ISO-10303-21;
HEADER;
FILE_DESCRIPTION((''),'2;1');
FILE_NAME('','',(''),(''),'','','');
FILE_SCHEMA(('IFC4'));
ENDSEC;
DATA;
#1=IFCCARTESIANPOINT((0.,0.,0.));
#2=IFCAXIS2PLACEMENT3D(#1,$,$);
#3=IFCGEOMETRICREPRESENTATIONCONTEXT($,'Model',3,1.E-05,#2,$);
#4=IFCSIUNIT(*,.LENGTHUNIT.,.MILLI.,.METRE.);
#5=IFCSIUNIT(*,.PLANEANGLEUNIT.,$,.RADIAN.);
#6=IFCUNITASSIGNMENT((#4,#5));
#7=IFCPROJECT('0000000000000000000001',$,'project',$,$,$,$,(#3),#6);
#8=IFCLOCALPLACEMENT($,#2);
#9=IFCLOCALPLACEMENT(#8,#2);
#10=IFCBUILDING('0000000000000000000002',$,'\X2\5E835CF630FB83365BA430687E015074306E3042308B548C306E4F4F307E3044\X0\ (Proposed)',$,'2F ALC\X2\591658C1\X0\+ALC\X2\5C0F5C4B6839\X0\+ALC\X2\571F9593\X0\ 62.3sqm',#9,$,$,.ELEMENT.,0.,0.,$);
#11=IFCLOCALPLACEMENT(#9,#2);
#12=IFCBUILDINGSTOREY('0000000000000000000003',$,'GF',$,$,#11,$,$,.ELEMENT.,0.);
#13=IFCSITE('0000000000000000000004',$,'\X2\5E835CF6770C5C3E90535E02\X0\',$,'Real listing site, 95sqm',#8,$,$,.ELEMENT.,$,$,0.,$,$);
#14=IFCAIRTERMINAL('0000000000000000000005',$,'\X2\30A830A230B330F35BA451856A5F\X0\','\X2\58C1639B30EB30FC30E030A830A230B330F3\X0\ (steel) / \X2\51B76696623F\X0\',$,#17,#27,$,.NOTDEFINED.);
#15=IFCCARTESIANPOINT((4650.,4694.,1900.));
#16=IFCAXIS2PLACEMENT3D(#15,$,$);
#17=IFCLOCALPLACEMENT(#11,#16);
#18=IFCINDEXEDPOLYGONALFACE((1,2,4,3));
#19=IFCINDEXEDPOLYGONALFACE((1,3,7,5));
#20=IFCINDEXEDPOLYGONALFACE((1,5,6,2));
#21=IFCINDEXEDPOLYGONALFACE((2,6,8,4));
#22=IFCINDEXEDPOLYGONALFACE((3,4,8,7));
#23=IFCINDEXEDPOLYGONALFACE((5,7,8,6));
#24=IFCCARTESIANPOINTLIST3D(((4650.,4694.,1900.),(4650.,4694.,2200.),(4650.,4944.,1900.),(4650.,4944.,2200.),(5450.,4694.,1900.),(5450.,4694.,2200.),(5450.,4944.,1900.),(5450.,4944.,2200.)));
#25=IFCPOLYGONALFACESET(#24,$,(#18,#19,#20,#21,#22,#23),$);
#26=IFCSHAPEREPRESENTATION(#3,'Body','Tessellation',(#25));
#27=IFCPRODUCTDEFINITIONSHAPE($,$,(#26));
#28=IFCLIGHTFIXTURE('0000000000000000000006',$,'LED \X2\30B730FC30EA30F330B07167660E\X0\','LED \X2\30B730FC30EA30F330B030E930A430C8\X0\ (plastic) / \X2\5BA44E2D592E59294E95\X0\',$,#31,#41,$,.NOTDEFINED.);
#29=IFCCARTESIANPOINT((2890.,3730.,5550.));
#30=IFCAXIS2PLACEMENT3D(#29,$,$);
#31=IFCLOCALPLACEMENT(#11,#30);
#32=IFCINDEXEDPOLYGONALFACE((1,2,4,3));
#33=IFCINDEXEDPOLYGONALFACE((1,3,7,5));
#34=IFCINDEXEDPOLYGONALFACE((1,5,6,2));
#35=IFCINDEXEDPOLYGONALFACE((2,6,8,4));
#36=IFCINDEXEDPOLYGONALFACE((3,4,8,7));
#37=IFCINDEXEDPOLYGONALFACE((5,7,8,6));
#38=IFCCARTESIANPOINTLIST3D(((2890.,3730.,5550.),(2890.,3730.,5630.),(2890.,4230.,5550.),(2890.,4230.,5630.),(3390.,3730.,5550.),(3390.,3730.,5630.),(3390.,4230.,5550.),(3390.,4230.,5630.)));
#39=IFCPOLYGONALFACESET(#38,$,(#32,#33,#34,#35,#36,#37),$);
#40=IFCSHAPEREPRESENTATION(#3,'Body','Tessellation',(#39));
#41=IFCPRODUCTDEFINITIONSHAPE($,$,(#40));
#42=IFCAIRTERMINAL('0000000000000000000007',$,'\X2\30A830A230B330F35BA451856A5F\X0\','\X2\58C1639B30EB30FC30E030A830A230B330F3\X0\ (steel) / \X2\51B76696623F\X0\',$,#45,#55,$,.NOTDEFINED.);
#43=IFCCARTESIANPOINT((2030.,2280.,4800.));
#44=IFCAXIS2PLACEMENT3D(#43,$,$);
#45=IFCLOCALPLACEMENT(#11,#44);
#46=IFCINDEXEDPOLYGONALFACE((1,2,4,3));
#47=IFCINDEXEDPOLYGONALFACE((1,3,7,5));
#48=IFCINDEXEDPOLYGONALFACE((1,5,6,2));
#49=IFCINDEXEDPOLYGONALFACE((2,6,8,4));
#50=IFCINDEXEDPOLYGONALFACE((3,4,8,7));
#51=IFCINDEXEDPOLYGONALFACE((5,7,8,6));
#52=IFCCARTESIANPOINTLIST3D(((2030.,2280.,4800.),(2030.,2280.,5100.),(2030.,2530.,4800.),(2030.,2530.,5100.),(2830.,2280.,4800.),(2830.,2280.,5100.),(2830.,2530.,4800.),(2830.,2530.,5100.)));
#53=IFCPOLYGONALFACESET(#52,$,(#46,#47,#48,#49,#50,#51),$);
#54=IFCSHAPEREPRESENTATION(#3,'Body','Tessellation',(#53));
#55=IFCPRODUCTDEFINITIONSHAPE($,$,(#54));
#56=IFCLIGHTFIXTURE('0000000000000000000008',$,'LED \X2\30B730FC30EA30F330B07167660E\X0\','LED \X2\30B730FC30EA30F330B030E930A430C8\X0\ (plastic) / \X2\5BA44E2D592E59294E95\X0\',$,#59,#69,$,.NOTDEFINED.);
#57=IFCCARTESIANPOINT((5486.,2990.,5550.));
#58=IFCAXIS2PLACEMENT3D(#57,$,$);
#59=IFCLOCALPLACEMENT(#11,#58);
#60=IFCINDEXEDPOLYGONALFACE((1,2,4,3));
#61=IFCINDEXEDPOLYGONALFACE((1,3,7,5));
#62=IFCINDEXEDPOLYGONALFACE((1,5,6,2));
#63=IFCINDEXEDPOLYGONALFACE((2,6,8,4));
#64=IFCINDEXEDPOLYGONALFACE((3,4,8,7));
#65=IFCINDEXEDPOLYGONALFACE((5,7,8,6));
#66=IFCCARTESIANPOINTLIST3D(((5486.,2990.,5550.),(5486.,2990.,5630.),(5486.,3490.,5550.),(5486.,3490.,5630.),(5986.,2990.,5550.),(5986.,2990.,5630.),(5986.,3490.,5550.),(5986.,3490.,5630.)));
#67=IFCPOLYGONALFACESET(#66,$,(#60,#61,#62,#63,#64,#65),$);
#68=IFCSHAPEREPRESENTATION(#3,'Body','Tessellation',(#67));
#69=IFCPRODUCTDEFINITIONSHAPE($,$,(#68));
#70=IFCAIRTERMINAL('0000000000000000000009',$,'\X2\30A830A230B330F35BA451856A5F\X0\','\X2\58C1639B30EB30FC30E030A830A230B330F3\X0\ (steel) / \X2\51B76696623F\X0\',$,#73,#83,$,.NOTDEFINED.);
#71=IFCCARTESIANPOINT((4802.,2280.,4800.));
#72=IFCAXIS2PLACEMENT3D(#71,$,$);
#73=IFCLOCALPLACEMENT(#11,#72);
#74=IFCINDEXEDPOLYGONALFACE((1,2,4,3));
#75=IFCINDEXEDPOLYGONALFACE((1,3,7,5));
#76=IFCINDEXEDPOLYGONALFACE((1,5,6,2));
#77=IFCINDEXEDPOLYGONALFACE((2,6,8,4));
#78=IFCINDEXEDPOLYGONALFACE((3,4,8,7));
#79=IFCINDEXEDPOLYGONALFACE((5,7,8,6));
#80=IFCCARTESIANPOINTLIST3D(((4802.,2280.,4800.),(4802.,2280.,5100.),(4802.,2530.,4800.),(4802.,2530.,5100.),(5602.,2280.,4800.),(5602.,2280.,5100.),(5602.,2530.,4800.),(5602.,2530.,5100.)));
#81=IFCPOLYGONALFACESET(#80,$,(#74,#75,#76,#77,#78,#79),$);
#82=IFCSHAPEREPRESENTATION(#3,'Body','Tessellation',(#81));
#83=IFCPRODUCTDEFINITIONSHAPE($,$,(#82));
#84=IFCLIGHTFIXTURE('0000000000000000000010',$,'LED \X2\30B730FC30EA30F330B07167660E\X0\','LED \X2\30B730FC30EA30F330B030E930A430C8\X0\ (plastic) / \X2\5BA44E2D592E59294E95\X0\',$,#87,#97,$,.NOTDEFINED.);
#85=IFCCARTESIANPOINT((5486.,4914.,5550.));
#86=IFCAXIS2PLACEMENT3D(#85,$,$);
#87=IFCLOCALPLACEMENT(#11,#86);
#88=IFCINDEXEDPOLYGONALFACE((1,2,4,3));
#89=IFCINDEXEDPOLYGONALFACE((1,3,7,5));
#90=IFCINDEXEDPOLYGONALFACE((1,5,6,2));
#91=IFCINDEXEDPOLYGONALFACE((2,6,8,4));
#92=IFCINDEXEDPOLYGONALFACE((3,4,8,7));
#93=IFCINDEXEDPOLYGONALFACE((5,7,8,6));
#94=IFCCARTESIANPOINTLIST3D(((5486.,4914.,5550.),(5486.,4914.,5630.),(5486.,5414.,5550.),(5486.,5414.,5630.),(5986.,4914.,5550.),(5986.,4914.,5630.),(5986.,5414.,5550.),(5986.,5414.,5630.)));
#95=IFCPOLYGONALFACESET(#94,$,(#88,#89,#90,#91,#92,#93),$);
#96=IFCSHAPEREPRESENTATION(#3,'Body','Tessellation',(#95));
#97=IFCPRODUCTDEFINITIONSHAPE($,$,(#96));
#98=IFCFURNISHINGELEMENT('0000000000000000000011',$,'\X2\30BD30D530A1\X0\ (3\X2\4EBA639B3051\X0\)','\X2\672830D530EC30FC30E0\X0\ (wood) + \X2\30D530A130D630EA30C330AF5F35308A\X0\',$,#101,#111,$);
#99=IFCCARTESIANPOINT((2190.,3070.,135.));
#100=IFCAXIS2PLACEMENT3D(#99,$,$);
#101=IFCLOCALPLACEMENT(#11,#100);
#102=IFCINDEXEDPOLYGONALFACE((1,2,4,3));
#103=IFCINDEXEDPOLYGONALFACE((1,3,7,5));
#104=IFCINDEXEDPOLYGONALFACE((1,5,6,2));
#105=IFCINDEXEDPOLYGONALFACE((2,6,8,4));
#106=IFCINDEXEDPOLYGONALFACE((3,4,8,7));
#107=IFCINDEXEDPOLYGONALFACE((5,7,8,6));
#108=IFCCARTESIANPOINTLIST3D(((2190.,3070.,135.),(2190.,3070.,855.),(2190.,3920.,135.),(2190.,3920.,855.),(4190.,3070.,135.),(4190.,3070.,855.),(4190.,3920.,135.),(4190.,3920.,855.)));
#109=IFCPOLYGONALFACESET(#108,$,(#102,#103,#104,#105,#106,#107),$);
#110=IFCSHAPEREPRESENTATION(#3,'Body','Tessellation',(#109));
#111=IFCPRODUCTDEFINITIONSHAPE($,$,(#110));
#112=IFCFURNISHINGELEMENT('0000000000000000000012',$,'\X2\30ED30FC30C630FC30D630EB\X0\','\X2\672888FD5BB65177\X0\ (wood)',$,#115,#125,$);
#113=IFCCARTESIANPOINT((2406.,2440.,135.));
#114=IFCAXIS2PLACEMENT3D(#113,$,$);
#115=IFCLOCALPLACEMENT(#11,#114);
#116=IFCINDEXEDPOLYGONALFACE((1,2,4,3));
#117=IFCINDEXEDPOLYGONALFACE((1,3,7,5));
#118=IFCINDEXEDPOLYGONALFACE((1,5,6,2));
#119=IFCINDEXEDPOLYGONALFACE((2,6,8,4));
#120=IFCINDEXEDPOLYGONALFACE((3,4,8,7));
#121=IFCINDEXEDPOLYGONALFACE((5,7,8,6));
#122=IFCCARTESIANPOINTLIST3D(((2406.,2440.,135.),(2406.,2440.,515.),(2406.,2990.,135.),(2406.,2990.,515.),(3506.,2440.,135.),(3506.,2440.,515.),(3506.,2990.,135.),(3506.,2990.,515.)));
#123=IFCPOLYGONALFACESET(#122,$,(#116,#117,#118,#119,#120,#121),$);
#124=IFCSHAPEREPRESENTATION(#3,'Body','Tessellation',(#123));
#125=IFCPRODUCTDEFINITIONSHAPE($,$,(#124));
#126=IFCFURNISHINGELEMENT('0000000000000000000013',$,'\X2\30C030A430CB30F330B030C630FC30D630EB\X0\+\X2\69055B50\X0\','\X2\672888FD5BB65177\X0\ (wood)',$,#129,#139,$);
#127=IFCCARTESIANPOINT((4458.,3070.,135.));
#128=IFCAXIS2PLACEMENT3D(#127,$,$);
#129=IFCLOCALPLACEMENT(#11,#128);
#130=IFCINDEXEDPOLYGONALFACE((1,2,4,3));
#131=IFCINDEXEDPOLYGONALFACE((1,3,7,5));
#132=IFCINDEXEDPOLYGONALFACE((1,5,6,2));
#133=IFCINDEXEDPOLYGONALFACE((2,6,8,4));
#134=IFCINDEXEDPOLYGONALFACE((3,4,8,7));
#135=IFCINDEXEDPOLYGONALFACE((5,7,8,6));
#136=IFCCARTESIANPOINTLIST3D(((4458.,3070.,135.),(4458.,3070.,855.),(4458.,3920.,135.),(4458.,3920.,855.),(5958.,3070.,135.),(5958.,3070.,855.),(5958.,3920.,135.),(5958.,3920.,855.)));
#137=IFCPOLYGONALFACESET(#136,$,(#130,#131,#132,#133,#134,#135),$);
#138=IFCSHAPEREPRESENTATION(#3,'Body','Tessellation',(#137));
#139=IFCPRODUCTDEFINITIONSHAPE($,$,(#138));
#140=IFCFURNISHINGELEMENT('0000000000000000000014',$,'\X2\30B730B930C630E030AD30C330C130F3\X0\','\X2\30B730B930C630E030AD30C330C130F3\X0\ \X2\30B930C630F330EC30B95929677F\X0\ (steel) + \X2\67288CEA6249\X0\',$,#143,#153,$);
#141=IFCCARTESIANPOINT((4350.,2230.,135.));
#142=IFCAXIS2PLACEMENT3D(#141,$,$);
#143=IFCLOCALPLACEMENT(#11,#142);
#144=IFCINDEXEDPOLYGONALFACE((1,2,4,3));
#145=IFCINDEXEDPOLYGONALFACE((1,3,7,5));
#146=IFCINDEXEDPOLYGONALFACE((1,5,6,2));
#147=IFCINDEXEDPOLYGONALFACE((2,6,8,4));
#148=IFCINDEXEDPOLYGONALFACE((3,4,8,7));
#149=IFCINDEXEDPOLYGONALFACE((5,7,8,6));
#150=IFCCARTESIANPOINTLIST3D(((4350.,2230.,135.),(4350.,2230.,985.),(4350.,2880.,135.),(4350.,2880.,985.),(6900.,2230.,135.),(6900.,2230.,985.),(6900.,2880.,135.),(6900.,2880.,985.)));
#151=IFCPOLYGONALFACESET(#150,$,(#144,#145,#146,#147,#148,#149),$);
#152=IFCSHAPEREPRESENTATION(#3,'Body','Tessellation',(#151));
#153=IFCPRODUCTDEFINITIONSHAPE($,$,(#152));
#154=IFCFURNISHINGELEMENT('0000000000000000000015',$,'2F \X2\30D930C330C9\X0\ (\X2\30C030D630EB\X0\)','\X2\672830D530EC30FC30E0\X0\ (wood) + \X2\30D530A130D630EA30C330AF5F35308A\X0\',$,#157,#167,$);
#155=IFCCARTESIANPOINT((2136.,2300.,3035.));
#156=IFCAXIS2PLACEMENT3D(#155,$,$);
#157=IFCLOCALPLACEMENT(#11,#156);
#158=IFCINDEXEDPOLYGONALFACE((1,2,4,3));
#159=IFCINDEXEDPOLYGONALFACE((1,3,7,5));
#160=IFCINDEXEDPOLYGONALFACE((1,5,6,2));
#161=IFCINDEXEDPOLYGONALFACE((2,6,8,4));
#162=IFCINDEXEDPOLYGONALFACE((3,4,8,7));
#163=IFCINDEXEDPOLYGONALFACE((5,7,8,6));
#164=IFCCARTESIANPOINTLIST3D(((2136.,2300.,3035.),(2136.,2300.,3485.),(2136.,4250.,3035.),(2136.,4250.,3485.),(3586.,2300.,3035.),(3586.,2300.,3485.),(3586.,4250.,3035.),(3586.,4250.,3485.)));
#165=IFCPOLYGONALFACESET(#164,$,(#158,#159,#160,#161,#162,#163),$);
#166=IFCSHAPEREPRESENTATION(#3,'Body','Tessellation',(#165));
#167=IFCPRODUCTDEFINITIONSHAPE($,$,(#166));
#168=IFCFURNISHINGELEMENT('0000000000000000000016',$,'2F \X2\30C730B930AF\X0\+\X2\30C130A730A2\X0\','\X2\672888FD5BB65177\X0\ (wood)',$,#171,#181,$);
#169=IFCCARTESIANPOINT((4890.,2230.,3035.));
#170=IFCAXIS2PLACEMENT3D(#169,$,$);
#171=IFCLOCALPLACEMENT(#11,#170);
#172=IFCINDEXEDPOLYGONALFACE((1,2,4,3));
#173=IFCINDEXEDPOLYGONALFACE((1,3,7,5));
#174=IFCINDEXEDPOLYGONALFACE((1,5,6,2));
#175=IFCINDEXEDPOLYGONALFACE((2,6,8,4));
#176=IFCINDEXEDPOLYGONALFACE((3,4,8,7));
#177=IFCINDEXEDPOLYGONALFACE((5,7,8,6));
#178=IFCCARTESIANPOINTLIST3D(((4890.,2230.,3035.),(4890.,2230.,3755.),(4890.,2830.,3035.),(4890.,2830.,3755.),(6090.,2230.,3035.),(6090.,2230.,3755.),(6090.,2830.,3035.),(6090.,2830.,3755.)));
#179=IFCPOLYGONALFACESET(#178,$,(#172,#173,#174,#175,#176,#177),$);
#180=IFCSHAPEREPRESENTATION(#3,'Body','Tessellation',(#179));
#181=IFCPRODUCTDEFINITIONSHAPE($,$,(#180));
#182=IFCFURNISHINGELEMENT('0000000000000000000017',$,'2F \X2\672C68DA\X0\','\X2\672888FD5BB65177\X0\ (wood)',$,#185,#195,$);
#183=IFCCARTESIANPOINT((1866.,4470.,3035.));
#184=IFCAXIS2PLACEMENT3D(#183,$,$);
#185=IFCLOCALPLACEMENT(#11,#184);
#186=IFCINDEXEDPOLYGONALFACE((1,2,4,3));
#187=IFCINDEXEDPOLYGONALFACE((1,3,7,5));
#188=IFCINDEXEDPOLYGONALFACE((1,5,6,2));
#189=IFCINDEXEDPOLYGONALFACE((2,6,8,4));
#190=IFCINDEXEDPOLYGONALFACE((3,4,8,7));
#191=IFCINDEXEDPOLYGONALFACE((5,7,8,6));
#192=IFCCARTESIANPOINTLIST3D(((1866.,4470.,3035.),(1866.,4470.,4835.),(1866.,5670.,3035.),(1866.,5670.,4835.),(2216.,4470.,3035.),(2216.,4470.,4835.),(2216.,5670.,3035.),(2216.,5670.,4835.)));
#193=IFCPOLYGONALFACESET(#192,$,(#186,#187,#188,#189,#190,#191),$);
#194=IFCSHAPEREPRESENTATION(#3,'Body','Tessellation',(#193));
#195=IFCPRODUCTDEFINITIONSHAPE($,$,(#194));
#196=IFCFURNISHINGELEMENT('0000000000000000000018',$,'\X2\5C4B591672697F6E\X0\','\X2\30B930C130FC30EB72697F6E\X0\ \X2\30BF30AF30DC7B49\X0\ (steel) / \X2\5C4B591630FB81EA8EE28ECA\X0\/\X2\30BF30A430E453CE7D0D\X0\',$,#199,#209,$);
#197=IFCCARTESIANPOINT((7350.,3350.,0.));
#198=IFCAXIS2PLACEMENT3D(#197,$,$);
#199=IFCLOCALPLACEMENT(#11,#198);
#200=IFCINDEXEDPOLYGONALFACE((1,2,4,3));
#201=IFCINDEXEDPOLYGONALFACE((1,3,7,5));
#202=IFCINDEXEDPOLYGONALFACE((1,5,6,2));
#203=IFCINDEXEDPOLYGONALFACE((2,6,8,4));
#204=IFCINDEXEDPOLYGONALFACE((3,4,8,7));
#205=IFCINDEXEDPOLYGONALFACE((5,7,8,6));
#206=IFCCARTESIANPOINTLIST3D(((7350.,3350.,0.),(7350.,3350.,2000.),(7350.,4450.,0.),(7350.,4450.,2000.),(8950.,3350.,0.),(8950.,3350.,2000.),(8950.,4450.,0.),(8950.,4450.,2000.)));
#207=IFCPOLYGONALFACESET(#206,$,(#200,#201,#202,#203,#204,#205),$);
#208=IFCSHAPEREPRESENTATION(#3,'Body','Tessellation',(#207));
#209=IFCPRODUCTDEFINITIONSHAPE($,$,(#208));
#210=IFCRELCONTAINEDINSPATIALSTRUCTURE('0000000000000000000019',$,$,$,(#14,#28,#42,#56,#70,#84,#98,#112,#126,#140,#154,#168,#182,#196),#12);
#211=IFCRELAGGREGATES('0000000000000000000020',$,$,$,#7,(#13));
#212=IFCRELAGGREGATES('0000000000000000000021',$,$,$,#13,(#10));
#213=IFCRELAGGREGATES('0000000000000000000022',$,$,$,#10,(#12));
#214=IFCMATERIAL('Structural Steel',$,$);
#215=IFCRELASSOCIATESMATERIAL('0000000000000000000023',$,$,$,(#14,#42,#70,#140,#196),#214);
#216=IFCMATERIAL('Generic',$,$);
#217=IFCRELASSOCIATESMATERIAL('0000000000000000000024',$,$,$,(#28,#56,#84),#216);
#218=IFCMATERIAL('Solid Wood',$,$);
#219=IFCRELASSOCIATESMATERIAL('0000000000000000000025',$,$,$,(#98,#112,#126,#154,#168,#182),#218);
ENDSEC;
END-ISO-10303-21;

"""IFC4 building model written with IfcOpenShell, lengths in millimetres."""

from ifc_helpers import new_model, si_unit, frame, frame_2d, origin, place, context, project, spatial, rectangle, extrude, material, element, save


model = new_model("IFC4")

# Units and contexts
model_context = context("Model", 3, precision=1e-05, world=origin())
ifc_project = project(units=[si_unit("LENGTHUNIT", "METRE", prefix="MILLI"), si_unit("PLANEANGLEUNIT", "RADIAN")], contexts=[model_context])

# Site, building, storey
site_placement = place(None, origin())
site = spatial("IfcSite", under=ifc_project, at=site_placement, Name="広島県尾道市", ObjectType="Real listing site, 95sqm", CompositionType="ELEMENT", RefElevation=0.0)
building_placement = place(site_placement, origin())
building = spatial("IfcBuilding", under=site, at=building_placement, Name="広島・茶室と縁側のある和の住まい (Proposed)", ObjectType="2F ALC外壁+ALC小屋根+ALC土間 62.3sqm", CompositionType="ELEMENT", ElevationOfRefHeight=0.0, ElevationOfTerrain=0.0)
storey_placement = place(building_placement, origin())
storey = spatial("IfcBuildingStorey", under=building, at=storey_placement, Name="GF", CompositionType="ELEMENT", Elevation=0.0)

# Shared definitions
ifc_material_1 = material(Name="Solid Wood")

# Shared definitions
ifc_material_2 = material(Name="Structural Steel")

# Shared definitions
ifc_material_3 = material(Name="Generic")

# Air terminal
air_terminal_1_placement = place(storey_placement, frame((4650.0, 4694.0, 1900.0)))
element("IfcAirTerminal", 1, at=air_terminal_1_placement, inside=storey, material=ifc_material_2, Name="エアコン室内機", Description="壁掛ルームエアコン (steel) / 冷暖房", PredefinedType="NOTDEFINED", context=model_context, shape_type="SweptSolid", body=[
    extrude(rectangle(XDim=800.0, YDim=250.0, at=frame_2d((400.0, 125.0))), frame((4650.0, 4694.0, 1900.0)), (0.0, 0.0, 1.0), 300.0),
])

# Light fixture
light_fixture_1_placement = place(storey_placement, frame((2890.0, 3730.0, 5550.0)))
element("IfcLightFixture", 2, at=light_fixture_1_placement, inside=storey, material=ifc_material_3, Name="LED シーリング照明", Description="LED シーリングライト (plastic) / 室中央天井", PredefinedType="NOTDEFINED", context=model_context, shape_type="SweptSolid", body=[
    extrude(rectangle(XDim=500.0, YDim=500.0, at=frame_2d((250.0, 250.0))), frame((2890.0, 3730.0, 5550.0)), (0.0, 0.0, 1.0), 80.0),
])

# Air terminal
air_terminal_2_placement = place(storey_placement, frame((2030.0, 2280.0, 4800.0)))
element("IfcAirTerminal", 3, at=air_terminal_2_placement, inside=storey, material=ifc_material_2, Name="エアコン室内機", Description="壁掛ルームエアコン (steel) / 冷暖房", PredefinedType="NOTDEFINED", context=model_context, shape_type="SweptSolid", body=[
    extrude(rectangle(XDim=800.0, YDim=250.0, at=frame_2d((400.0, 125.0))), frame((2030.0, 2280.0, 4800.0)), (0.0, 0.0, 1.0), 300.0),
])

# Light fixture
light_fixture_2_placement = place(storey_placement, frame((5486.0, 2990.0, 5550.0)))
element("IfcLightFixture", 4, at=light_fixture_2_placement, inside=storey, material=ifc_material_3, Name="LED シーリング照明", Description="LED シーリングライト (plastic) / 室中央天井", PredefinedType="NOTDEFINED", context=model_context, shape_type="SweptSolid", body=[
    extrude(rectangle(XDim=500.0, YDim=500.0, at=frame_2d((250.0, 250.0))), frame((5486.0, 2990.0, 5550.0)), (0.0, 0.0, 1.0), 80.0),
])

# Air terminal
air_terminal_3_placement = place(storey_placement, frame((4802.0, 2280.0, 4800.0)))
element("IfcAirTerminal", 5, at=air_terminal_3_placement, inside=storey, material=ifc_material_2, Name="エアコン室内機", Description="壁掛ルームエアコン (steel) / 冷暖房", PredefinedType="NOTDEFINED", context=model_context, shape_type="SweptSolid", body=[
    extrude(rectangle(XDim=800.0, YDim=250.0, at=frame_2d((400.0, 125.0))), frame((4802.0, 2280.0, 4800.0)), (0.0, 0.0, 1.0), 300.0),
])

# Light fixture
light_fixture_3_placement = place(storey_placement, frame((5486.0, 4914.0, 5550.0)))
element("IfcLightFixture", 6, at=light_fixture_3_placement, inside=storey, material=ifc_material_3, Name="LED シーリング照明", Description="LED シーリングライト (plastic) / 室中央天井", PredefinedType="NOTDEFINED", context=model_context, shape_type="SweptSolid", body=[
    extrude(rectangle(XDim=500.0, YDim=500.0, at=frame_2d((250.0, 250.0))), frame((5486.0, 4914.0, 5550.0)), (0.0, 0.0, 1.0), 80.0),
])

# Furnishing elements
furnishing_1_placement = place(storey_placement, frame((2190.0, 3070.0, 135.0)))
element("IfcFurnishingElement", 7, at=furnishing_1_placement, inside=storey, material=ifc_material_1, Name="ソファ (3人掛け)", Description="木フレーム (wood) + ファブリック張り", context=model_context, shape_type="SweptSolid", body=[
    extrude(rectangle(XDim=2000.0, YDim=850.0, at=frame_2d((1000.0, 425.0))), frame((2190.0, 3070.0, 135.0)), (0.0, 0.0, 1.0), 720.0),
])
furnishing_2_placement = place(storey_placement, frame((2406.0, 2440.0, 135.0)))
element("IfcFurnishingElement", 8, at=furnishing_2_placement, inside=storey, material=ifc_material_1, Name="ローテーブル", Description="木製家具 (wood)", context=model_context, shape_type="SweptSolid", body=[
    extrude(rectangle(XDim=1100.0, YDim=550.0, at=frame_2d((550.0, 275.0))), frame((2406.0, 2440.0, 135.0)), (0.0, 0.0, 1.0), 380.0),
])
furnishing_3_placement = place(storey_placement, frame((4458.0, 3070.0, 135.0)))
element("IfcFurnishingElement", 9, at=furnishing_3_placement, inside=storey, material=ifc_material_1, Name="ダイニングテーブル+椅子", Description="木製家具 (wood)", context=model_context, shape_type="SweptSolid", body=[
    extrude(rectangle(XDim=1500.0, YDim=850.0, at=frame_2d((750.0, 425.0))), frame((4458.0, 3070.0, 135.0)), (0.0, 0.0, 1.0), 720.0),
])
furnishing_4_placement = place(storey_placement, frame((4350.0, 2230.0, 135.0)))
element("IfcFurnishingElement", 10, at=furnishing_4_placement, inside=storey, material=ifc_material_2, Name="システムキッチン", Description="システムキッチン ステンレス天板 (steel) + 木質扉", context=model_context, shape_type="SweptSolid", body=[
    extrude(rectangle(XDim=2550.0, YDim=650.0, at=frame_2d((1275.0, 325.0))), frame((4350.0, 2230.0, 135.0)), (0.0, 0.0, 1.0), 850.0),
])
furnishing_5_placement = place(storey_placement, frame((2136.0, 2300.0, 3035.0)))
element("IfcFurnishingElement", 11, at=furnishing_5_placement, inside=storey, material=ifc_material_1, Name="2F ベッド (ダブル)", Description="木フレーム (wood) + ファブリック張り", context=model_context, shape_type="SweptSolid", body=[
    extrude(rectangle(XDim=1450.0, YDim=1950.0, at=frame_2d((725.0, 975.0))), frame((2136.0, 2300.0, 3035.0)), (0.0, 0.0, 1.0), 450.0),
])
furnishing_6_placement = place(storey_placement, frame((4890.0, 2230.0, 3035.0)))
element("IfcFurnishingElement", 12, at=furnishing_6_placement, inside=storey, material=ifc_material_1, Name="2F デスク+チェア", Description="木製家具 (wood)", context=model_context, shape_type="SweptSolid", body=[
    extrude(rectangle(XDim=1200.0, YDim=600.0, at=frame_2d((600.0, 300.0))), frame((4890.0, 2230.0, 3035.0)), (0.0, 0.0, 1.0), 720.0),
])
furnishing_7_placement = place(storey_placement, frame((1866.0, 4470.0, 3035.0)))
element("IfcFurnishingElement", 13, at=furnishing_7_placement, inside=storey, material=ifc_material_1, Name="2F 本棚", Description="木製家具 (wood)", context=model_context, shape_type="SweptSolid", body=[
    extrude(rectangle(XDim=350.0, YDim=1200.0, at=frame_2d((175.0, 600.0))), frame((1866.0, 4470.0, 3035.0)), (0.0, 0.0, 1.0), 1800.0),
])
furnishing_8_placement = place(storey_placement, frame((7350.0, 3350.0, 0.0)))
element("IfcFurnishingElement", 14, at=furnishing_8_placement, inside=storey, material=ifc_material_2, Name="屋外物置", Description="スチール物置 タクボ等 (steel) / 屋外・自転車/タイヤ収納", context=model_context, shape_type="SweptSolid", body=[
    extrude(rectangle(XDim=1600.0, YDim=1100.0, at=frame_2d((800.0, 550.0))), frame((7350.0, 3350.0, 0.0)), (0.0, 0.0, 1.0), 2000.0),
])

save(model, "model.ifc")
